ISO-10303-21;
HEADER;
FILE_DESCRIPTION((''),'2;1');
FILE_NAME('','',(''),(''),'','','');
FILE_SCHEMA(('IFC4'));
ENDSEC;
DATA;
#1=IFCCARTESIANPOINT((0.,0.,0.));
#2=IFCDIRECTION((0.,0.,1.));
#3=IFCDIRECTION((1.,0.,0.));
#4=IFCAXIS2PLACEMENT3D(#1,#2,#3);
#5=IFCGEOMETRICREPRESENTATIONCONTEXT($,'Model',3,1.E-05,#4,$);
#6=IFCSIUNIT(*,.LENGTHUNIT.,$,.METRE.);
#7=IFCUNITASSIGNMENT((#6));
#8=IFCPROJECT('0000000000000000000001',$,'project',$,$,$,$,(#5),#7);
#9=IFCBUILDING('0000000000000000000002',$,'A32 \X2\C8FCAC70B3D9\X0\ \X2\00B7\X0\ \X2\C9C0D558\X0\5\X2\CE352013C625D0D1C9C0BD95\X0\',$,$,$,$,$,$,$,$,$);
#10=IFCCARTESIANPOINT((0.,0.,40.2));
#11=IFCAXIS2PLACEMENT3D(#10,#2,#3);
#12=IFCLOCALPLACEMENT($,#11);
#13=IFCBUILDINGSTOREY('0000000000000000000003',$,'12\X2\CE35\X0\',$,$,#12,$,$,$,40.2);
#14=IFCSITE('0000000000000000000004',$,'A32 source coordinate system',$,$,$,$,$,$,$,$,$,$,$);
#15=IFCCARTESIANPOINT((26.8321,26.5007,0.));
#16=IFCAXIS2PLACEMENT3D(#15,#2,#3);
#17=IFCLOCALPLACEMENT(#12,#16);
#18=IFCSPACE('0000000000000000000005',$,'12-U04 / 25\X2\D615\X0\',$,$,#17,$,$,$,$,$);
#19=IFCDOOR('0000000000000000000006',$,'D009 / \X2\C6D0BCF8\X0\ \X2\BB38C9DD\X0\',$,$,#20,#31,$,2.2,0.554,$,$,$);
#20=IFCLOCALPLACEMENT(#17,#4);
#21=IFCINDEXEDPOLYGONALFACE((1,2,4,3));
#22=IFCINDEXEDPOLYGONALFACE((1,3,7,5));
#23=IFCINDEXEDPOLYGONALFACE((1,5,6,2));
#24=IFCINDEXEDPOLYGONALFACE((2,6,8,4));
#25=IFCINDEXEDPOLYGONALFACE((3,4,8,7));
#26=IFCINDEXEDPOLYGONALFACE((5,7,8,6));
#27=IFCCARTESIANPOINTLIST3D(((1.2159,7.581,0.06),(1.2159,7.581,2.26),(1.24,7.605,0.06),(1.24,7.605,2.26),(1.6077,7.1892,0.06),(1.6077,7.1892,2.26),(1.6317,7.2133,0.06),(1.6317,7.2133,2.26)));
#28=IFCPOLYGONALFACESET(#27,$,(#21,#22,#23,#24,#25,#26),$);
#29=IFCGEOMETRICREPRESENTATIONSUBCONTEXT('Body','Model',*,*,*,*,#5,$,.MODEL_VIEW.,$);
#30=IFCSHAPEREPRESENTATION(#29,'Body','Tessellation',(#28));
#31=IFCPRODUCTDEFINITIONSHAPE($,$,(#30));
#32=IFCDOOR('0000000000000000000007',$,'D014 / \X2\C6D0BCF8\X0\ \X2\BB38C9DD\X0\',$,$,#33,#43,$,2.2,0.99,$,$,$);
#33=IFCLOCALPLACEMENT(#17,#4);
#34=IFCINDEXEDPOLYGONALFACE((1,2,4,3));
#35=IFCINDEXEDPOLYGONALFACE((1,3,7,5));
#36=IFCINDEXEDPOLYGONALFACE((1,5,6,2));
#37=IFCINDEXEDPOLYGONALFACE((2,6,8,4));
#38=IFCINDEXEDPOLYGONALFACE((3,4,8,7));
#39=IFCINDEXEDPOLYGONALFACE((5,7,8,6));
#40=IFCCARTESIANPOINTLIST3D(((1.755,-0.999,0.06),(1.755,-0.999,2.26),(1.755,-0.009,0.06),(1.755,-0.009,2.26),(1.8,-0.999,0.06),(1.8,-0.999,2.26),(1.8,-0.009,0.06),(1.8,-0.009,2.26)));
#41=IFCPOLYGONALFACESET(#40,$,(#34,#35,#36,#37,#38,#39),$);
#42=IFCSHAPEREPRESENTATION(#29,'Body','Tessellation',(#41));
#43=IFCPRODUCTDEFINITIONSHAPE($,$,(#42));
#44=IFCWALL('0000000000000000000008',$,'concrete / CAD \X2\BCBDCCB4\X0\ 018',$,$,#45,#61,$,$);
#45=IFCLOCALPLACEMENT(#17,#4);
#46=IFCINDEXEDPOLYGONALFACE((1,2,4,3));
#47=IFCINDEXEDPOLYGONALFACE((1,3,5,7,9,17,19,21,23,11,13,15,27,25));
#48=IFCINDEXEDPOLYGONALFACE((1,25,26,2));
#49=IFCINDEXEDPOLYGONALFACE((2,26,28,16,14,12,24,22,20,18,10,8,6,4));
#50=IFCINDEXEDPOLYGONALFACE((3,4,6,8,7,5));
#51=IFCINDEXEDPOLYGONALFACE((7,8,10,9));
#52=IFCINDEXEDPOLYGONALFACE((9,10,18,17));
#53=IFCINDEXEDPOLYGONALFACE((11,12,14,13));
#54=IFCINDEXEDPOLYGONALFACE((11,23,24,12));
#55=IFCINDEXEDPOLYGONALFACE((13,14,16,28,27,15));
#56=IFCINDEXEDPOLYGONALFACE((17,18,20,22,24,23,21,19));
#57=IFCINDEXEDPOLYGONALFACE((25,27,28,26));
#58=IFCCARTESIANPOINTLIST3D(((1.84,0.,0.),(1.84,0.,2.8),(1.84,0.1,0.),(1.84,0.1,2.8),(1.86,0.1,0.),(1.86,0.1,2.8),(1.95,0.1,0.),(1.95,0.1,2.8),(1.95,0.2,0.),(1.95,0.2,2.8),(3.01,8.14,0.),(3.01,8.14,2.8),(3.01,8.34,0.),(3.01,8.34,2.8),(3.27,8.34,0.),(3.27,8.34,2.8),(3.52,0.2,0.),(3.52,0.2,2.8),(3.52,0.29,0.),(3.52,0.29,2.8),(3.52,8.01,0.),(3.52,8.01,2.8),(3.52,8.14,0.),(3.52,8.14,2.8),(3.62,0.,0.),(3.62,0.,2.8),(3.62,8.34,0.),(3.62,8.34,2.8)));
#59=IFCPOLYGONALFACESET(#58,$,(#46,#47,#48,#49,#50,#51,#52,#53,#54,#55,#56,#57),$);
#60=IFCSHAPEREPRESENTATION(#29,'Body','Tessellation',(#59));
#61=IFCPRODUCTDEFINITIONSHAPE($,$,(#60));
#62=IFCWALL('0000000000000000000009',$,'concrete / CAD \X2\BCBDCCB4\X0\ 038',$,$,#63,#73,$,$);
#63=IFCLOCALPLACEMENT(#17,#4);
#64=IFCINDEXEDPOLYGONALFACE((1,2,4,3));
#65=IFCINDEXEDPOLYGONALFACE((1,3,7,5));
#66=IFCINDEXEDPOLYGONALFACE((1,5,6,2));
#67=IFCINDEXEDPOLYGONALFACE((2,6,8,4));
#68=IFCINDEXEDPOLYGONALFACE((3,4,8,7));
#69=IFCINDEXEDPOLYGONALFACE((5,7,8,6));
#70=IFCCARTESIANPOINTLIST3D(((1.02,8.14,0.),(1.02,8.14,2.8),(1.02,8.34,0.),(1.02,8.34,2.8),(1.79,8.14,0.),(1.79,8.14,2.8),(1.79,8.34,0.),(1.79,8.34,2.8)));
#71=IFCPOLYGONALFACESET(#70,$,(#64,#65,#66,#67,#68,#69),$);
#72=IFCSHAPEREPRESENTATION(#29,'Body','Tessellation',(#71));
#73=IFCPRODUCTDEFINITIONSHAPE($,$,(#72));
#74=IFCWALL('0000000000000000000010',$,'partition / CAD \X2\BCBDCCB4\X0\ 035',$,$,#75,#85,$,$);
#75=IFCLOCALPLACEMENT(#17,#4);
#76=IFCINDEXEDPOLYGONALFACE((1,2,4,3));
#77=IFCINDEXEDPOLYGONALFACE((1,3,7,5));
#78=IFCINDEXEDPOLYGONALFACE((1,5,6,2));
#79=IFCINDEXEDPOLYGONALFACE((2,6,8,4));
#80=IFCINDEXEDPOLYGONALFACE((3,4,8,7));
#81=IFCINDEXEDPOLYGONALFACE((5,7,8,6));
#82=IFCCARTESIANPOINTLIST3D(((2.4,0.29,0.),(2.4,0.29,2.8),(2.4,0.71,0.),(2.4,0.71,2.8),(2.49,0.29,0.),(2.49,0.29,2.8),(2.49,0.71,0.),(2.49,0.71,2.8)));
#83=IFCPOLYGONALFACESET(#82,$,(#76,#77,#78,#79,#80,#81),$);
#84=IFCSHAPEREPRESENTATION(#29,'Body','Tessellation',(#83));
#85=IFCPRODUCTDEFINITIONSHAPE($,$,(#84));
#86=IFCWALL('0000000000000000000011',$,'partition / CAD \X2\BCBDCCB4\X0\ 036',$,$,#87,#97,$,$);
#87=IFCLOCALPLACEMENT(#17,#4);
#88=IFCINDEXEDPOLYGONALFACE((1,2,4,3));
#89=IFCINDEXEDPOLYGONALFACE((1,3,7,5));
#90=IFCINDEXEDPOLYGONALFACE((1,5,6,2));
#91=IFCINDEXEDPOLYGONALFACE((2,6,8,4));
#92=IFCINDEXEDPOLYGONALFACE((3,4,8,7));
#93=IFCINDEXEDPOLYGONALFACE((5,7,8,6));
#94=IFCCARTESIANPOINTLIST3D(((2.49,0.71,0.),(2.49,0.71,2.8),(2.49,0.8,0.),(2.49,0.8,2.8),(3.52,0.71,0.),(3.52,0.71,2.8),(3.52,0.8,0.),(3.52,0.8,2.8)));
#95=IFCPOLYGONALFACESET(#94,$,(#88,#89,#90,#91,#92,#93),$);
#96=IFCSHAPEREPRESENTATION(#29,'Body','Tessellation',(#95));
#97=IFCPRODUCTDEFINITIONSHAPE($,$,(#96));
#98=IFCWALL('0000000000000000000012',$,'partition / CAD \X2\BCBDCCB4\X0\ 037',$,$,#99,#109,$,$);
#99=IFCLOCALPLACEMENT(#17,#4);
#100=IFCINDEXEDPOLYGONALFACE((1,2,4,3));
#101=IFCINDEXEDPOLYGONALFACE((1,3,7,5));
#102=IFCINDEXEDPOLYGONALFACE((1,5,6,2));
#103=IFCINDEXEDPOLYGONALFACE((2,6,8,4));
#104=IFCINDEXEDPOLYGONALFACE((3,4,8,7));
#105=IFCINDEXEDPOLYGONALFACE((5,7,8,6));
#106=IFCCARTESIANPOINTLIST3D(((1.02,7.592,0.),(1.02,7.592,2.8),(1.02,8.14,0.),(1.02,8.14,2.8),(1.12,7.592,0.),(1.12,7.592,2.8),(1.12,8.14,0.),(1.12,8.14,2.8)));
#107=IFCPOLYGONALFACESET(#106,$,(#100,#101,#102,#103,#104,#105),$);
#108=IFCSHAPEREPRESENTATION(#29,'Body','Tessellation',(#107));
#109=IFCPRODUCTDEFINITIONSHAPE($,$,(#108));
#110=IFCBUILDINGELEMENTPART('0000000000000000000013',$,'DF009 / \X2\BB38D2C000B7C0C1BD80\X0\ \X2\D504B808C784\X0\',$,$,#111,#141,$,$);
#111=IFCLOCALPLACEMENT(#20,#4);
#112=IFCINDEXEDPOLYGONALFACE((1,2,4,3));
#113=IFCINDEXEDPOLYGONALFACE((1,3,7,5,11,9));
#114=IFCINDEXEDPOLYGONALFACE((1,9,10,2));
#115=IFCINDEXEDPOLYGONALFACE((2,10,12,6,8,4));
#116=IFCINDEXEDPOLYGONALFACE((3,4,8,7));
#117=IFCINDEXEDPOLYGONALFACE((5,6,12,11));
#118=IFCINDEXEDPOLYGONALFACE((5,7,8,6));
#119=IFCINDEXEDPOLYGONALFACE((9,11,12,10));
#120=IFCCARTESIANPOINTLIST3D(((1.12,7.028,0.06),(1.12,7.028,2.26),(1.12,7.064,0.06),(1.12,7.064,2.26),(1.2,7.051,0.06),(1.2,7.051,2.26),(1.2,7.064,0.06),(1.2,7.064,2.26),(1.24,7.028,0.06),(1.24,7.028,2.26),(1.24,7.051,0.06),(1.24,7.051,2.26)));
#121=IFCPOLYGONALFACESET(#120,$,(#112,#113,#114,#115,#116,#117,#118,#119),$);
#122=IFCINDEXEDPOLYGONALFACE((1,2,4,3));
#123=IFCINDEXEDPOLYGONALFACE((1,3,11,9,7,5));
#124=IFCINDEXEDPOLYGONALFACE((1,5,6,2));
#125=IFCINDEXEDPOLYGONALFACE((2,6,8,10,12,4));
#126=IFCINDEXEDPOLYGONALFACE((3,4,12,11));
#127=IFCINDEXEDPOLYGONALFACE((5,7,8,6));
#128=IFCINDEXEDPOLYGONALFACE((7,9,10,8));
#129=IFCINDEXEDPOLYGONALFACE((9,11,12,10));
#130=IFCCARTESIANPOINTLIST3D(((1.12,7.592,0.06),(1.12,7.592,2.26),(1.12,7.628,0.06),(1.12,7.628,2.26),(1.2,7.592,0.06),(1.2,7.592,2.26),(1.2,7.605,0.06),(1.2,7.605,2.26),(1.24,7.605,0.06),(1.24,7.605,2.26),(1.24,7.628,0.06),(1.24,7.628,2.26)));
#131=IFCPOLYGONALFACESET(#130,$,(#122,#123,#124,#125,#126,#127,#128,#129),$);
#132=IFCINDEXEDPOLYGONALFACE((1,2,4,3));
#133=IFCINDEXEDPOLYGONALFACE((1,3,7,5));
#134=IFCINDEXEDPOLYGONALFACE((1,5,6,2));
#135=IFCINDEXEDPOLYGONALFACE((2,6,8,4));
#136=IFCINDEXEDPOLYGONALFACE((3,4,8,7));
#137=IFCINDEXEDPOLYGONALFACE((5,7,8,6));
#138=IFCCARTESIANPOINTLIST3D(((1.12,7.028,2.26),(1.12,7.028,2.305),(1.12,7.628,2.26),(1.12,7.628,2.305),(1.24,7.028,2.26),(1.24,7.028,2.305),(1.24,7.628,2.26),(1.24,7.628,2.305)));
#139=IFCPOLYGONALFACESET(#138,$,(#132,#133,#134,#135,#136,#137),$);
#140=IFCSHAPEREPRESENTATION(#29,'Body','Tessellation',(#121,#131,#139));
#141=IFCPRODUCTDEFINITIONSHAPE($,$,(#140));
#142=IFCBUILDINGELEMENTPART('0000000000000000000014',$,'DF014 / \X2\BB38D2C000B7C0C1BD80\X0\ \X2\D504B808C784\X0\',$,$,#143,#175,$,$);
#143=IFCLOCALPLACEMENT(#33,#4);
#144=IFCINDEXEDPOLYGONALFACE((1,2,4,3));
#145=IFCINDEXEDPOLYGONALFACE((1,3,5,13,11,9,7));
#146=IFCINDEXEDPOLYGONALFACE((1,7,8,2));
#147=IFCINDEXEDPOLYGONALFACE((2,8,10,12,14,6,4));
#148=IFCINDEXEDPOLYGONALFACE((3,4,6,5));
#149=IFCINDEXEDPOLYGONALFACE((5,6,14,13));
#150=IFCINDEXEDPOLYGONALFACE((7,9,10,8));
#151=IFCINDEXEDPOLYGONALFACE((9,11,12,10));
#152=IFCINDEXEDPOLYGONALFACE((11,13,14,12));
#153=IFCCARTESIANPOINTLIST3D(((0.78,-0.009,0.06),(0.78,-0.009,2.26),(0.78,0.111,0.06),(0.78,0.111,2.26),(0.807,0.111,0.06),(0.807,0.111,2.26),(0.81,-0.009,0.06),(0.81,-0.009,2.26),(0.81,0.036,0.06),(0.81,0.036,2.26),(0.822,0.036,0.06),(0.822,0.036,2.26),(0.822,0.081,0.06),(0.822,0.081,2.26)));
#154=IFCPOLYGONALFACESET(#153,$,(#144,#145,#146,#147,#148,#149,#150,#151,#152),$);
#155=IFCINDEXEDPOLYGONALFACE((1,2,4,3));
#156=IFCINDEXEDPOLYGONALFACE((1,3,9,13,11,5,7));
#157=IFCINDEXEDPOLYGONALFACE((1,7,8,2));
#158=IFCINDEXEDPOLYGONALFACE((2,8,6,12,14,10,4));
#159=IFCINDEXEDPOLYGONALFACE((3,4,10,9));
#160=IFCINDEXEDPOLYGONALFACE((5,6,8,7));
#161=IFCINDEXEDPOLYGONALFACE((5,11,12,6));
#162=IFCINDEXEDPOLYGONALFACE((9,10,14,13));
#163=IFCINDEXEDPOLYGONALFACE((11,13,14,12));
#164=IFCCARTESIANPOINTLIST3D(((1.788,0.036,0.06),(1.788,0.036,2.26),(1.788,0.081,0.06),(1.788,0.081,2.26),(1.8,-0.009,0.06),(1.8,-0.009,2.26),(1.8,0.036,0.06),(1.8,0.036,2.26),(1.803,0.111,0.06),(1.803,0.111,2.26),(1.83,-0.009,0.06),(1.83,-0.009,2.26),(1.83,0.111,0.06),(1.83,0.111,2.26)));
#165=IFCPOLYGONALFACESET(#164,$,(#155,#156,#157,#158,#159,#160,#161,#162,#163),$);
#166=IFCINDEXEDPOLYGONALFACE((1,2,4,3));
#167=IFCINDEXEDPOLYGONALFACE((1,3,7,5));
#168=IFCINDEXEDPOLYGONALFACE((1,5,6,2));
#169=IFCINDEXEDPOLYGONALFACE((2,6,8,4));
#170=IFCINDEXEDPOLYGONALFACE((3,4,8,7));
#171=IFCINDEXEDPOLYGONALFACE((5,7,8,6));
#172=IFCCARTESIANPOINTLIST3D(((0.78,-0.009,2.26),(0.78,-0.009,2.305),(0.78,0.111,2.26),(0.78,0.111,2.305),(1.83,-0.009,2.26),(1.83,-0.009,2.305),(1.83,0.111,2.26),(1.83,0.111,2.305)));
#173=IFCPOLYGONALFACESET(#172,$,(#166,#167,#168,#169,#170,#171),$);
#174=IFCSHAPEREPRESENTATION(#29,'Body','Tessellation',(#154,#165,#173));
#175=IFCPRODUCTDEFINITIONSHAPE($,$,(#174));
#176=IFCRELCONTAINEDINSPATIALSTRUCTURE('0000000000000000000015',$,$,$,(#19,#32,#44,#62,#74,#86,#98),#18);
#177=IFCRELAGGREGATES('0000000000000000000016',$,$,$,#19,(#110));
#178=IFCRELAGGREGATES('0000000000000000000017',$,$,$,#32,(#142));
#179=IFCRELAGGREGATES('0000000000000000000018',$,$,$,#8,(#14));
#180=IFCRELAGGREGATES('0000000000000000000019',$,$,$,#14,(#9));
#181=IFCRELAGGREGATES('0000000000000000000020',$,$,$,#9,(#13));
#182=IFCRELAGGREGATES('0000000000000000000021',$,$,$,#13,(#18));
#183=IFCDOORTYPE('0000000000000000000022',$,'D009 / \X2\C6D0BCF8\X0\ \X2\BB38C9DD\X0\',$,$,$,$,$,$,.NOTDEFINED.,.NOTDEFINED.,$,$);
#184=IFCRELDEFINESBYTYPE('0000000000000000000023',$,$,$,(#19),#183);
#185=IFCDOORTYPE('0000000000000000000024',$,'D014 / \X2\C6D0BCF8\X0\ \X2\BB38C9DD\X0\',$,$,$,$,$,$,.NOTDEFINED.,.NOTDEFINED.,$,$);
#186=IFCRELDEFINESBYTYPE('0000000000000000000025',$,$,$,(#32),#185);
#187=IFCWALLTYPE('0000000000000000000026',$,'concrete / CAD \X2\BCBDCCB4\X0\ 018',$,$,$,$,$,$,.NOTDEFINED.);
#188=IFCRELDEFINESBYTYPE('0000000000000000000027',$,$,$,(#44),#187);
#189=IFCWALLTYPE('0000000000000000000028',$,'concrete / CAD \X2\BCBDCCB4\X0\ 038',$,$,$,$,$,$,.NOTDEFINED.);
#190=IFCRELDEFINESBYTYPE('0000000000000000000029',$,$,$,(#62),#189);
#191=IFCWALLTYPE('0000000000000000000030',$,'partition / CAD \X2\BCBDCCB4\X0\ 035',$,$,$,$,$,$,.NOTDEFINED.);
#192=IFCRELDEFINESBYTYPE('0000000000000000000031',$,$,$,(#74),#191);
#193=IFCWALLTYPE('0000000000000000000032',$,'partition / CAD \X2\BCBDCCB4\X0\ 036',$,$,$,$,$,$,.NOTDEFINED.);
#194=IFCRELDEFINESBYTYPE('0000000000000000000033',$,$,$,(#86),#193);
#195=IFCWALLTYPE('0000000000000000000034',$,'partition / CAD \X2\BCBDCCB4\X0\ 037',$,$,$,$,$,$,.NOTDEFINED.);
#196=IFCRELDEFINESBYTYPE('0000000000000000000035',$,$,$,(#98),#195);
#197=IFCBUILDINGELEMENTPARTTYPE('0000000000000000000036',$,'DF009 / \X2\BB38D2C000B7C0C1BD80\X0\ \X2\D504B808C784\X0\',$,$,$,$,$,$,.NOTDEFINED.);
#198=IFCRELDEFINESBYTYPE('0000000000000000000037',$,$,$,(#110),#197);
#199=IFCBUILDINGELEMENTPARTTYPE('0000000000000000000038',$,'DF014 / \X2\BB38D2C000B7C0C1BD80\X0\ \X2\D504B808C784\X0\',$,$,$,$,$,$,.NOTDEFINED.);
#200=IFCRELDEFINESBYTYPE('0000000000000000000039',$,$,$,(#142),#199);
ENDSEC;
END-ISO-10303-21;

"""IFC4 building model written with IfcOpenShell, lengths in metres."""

from ifc_helpers import new_model, si_unit, frame, origin, origin_with_axes, place, context, subcontext, project, spatial, polyline, outline, extrude, source, transform, mapped, type_object, type_shapes, element, aggregate, save


model = new_model("IFC4")

# Units and contexts
model_context = context("Model", 3, precision=1e-05, world=origin_with_axes())
body_context = subcontext(model_context, "Body", "Model", "MODEL_VIEW")
ifc_project = project(units=[si_unit("LENGTHUNIT", "METRE")], contexts=[model_context])

# Site, building, storey, space
storey_placement = place(None, frame((0.0, 0.0, 40.2), z_axis=(0.0, 0.0, 1.0), x_axis=(1.0, 0.0, 0.0)))
space_placement = place(storey_placement, frame((26.8321, 26.5007, 0.0), z_axis=(0.0, 0.0, 1.0), x_axis=(1.0, 0.0, 0.0)))
site = spatial("IfcSite", under=ifc_project, Name="A32 source coordinate system")
building = spatial("IfcBuilding", under=site, Name="A32 주거동 · 지하5층–옥탑지붕")
storey = spatial("IfcBuildingStorey", under=building, at=storey_placement, Name="12층", Elevation=40.2)
space = spatial("IfcSpace", under=storey, at=space_placement, Name="12-U04 / 25형")

# Doors
door_type_1 = type_object("IfcDoorType", Name="D009 / 원본 문짝", OperationType="NOTDEFINED", PredefinedType="NOTDEFINED")
shared_shape_1 = source(origin(), body_context, "Body", "SweptSolid", [
    extrude(outline(polyline([(1.24, 7.605), (1.6317, 7.2133), (1.6077, 7.1892), (1.2159, 7.581), (1.24, 7.605)])), frame((0.0, 0.0, 0.06)), (0.0, 0.0, 1.0), 2.2),
])
type_shapes(door_type_1, [shared_shape_1])
door_1_placement = place(space_placement, origin_with_axes())
door_1 = element("IfcDoor", 1, at=door_1_placement, inside=space, type_object=door_type_1, Name="D009 / 원본 문짝", OverallHeight=2.2, OverallWidth=0.554, context=body_context, shape_type="MappedRepresentation", body=[
    mapped(shared_shape_1, transform((0.0, 0.0, 0.0), scale=1.0)),
])
door_type_2 = type_object("IfcDoorType", Name="D014 / 원본 문짝", OperationType="NOTDEFINED", PredefinedType="NOTDEFINED")
shared_shape_2 = source(origin(), body_context, "Body", "SweptSolid", [
    extrude(outline(polyline([(1.8, -0.009), (1.8, -0.999), (1.755, -0.999), (1.755, -0.009), (1.8, -0.009)])), frame((0.0, 0.0, 0.06)), (0.0, 0.0, 1.0), 2.2),
])
type_shapes(door_type_2, [shared_shape_2])
door_2_placement = place(space_placement, origin_with_axes())
door_2 = element("IfcDoor", 2, at=door_2_placement, inside=space, type_object=door_type_2, Name="D014 / 원본 문짝", OverallHeight=2.2, OverallWidth=0.99, context=body_context, shape_type="MappedRepresentation", body=[
    mapped(shared_shape_2, transform((0.0, 0.0, 0.0), scale=1.0)),
])

# Walls
wall_type_1 = type_object("IfcWallType", Name="concrete / CAD 벽체 018", PredefinedType="NOTDEFINED")
shared_shape_3 = source(origin(), body_context, "Body", "SweptSolid", [
    extrude(outline(polyline([(3.27, 8.34), (3.27, 8.34), (3.62, 8.34), (3.62, 0.0), (1.84, 0.0), (1.84, 0.1), (1.86, 0.1), (1.95, 0.1), (1.95, 0.2), (3.52, 0.2), (3.52, 0.29), (3.52, 8.01), (3.52, 8.14), (3.01, 8.14), (3.01, 8.34), (3.27, 8.34)])), origin(), (0.0, 0.0, 1.0), 2.8),
])
type_shapes(wall_type_1, [shared_shape_3])
wall_1_placement = place(space_placement, origin_with_axes())
element("IfcWall", 3, at=wall_1_placement, inside=space, type_object=wall_type_1, Name="concrete / CAD 벽체 018", context=body_context, shape_type="MappedRepresentation", body=[
    mapped(shared_shape_3, transform((0.0, 0.0, 0.0), scale=1.0)),
])
wall_type_2 = type_object("IfcWallType", Name="concrete / CAD 벽체 038", PredefinedType="NOTDEFINED")
shared_shape_4 = source(origin(), body_context, "Body", "SweptSolid", [
    extrude(outline(polyline([(1.02, 8.14), (1.02, 8.34), (1.79, 8.34), (1.79, 8.14), (1.02, 8.14)])), origin(), (0.0, 0.0, 1.0), 2.8),
])
type_shapes(wall_type_2, [shared_shape_4])
wall_2_placement = place(space_placement, origin_with_axes())
element("IfcWall", 4, at=wall_2_placement, inside=space, type_object=wall_type_2, Name="concrete / CAD 벽체 038", context=body_context, shape_type="MappedRepresentation", body=[
    mapped(shared_shape_4, transform((0.0, 0.0, 0.0), scale=1.0)),
])
wall_type_3 = type_object("IfcWallType", Name="partition / CAD 벽체 035", PredefinedType="NOTDEFINED")
shared_shape_5 = source(origin(), body_context, "Body", "SweptSolid", [
    extrude(outline(polyline([(2.49, 0.71), (2.49, 0.29), (2.4, 0.29), (2.4, 0.71), (2.49, 0.71)])), origin(), (0.0, 0.0, 1.0), 2.8),
])
type_shapes(wall_type_3, [shared_shape_5])
wall_3_placement = place(space_placement, origin_with_axes())
element("IfcWall", 5, at=wall_3_placement, inside=space, type_object=wall_type_3, Name="partition / CAD 벽체 035", context=body_context, shape_type="MappedRepresentation", body=[
    mapped(shared_shape_5, transform((0.0, 0.0, 0.0), scale=1.0)),
])
wall_type_4 = type_object("IfcWallType", Name="partition / CAD 벽체 036", PredefinedType="NOTDEFINED")
shared_shape_6 = source(origin(), body_context, "Body", "SweptSolid", [
    extrude(outline(polyline([(2.49, 0.8), (3.52, 0.8), (3.52, 0.71), (2.49, 0.71), (2.49, 0.8)])), origin(), (0.0, 0.0, 1.0), 2.8),
])
type_shapes(wall_type_4, [shared_shape_6])
wall_4_placement = place(space_placement, origin_with_axes())
element("IfcWall", 6, at=wall_4_placement, inside=space, type_object=wall_type_4, Name="partition / CAD 벽체 036", context=body_context, shape_type="MappedRepresentation", body=[
    mapped(shared_shape_6, transform((0.0, 0.0, 0.0), scale=1.0)),
])
wall_type_5 = type_object("IfcWallType", Name="partition / CAD 벽체 037", PredefinedType="NOTDEFINED")
shared_shape_7 = source(origin(), body_context, "Body", "SweptSolid", [
    extrude(outline(polyline([(1.02, 7.592), (1.02, 8.14), (1.12, 8.14), (1.12, 7.592), (1.02, 7.592)])), origin(), (0.0, 0.0, 1.0), 2.8),
])
type_shapes(wall_type_5, [shared_shape_7])
wall_5_placement = place(space_placement, origin_with_axes())
element("IfcWall", 7, at=wall_5_placement, inside=space, type_object=wall_type_5, Name="partition / CAD 벽체 037", context=body_context, shape_type="MappedRepresentation", body=[
    mapped(shared_shape_7, transform((0.0, 0.0, 0.0), scale=1.0)),
])

# Building element parts
building_element_part_type_1 = type_object("IfcBuildingElementPartType", Name="DF009 / 문틀·상부 프레임", PredefinedType="NOTDEFINED")
shared_shape_8 = source(origin(), body_context, "Body", "SweptSolid", [
    extrude(outline(polyline([(1.12, 7.064), (1.2, 7.064), (1.2, 7.051), (1.24, 7.051), (1.24, 7.028), (1.12, 7.028), (1.12, 7.064)])), frame((0.0, 0.0, 0.06)), (0.0, 0.0, 1.0), 2.2),
    extrude(outline(polyline([(1.24, 7.628), (1.24, 7.605), (1.2, 7.605), (1.2, 7.592), (1.12, 7.592), (1.12, 7.628), (1.24, 7.628)])), frame((0.0, 0.0, 0.06)), (0.0, 0.0, 1.0), 2.2),
    extrude(outline(polyline([(1.12, 7.028), (1.12, 7.628), (1.24, 7.628), (1.24, 7.028), (1.12, 7.028)])), frame((0.0, 0.0, 2.26)), (0.0, 0.0, 1.0), 0.045),
])
type_shapes(building_element_part_type_1, [shared_shape_8])
building_element_part_1_placement = place(door_1_placement, origin_with_axes())
building_element_part_1 = element("IfcBuildingElementPart", 8, at=building_element_part_1_placement, type_object=building_element_part_type_1, Name="DF009 / 문틀·상부 프레임", context=body_context, shape_type="MappedRepresentation", body=[
    mapped(shared_shape_8, transform((0.0, 0.0, 0.0), scale=1.0)),
])
aggregate(door_1, [building_element_part_1])
building_element_part_type_2 = type_object("IfcBuildingElementPartType", Name="DF014 / 문틀·상부 프레임", PredefinedType="NOTDEFINED")
shared_shape_9 = source(origin(), body_context, "Body", "SweptSolid", [
    extrude(outline(polyline([(0.78, 0.111), (0.807, 0.111), (0.822, 0.081), (0.822, 0.036), (0.81, 0.036), (0.81, -0.009), (0.78, -0.009), (0.78, 0.111)])), frame((0.0, 0.0, 0.06)), (0.0, 0.0, 1.0), 2.2),
    extrude(outline(polyline([(1.8, -0.009), (1.8, 0.036), (1.788, 0.036), (1.788, 0.081), (1.803, 0.111), (1.83, 0.111), (1.83, -0.009), (1.8, -0.009)])), frame((0.0, 0.0, 0.06)), (0.0, 0.0, 1.0), 2.2),
    extrude(outline(polyline([(0.78, -0.009), (0.78, 0.111), (1.83, 0.111), (1.83, -0.009), (0.78, -0.009)])), frame((0.0, 0.0, 2.26)), (0.0, 0.0, 1.0), 0.045),
])
type_shapes(building_element_part_type_2, [shared_shape_9])
building_element_part_2_placement = place(door_2_placement, origin_with_axes())
building_element_part_2 = element("IfcBuildingElementPart", 9, at=building_element_part_2_placement, type_object=building_element_part_type_2, Name="DF014 / 문틀·상부 프레임", context=body_context, shape_type="MappedRepresentation", body=[
    mapped(shared_shape_9, transform((0.0, 0.0, 0.0), scale=1.0)),
])
aggregate(door_2, [building_element_part_2])

save(model, "model.ifc")
